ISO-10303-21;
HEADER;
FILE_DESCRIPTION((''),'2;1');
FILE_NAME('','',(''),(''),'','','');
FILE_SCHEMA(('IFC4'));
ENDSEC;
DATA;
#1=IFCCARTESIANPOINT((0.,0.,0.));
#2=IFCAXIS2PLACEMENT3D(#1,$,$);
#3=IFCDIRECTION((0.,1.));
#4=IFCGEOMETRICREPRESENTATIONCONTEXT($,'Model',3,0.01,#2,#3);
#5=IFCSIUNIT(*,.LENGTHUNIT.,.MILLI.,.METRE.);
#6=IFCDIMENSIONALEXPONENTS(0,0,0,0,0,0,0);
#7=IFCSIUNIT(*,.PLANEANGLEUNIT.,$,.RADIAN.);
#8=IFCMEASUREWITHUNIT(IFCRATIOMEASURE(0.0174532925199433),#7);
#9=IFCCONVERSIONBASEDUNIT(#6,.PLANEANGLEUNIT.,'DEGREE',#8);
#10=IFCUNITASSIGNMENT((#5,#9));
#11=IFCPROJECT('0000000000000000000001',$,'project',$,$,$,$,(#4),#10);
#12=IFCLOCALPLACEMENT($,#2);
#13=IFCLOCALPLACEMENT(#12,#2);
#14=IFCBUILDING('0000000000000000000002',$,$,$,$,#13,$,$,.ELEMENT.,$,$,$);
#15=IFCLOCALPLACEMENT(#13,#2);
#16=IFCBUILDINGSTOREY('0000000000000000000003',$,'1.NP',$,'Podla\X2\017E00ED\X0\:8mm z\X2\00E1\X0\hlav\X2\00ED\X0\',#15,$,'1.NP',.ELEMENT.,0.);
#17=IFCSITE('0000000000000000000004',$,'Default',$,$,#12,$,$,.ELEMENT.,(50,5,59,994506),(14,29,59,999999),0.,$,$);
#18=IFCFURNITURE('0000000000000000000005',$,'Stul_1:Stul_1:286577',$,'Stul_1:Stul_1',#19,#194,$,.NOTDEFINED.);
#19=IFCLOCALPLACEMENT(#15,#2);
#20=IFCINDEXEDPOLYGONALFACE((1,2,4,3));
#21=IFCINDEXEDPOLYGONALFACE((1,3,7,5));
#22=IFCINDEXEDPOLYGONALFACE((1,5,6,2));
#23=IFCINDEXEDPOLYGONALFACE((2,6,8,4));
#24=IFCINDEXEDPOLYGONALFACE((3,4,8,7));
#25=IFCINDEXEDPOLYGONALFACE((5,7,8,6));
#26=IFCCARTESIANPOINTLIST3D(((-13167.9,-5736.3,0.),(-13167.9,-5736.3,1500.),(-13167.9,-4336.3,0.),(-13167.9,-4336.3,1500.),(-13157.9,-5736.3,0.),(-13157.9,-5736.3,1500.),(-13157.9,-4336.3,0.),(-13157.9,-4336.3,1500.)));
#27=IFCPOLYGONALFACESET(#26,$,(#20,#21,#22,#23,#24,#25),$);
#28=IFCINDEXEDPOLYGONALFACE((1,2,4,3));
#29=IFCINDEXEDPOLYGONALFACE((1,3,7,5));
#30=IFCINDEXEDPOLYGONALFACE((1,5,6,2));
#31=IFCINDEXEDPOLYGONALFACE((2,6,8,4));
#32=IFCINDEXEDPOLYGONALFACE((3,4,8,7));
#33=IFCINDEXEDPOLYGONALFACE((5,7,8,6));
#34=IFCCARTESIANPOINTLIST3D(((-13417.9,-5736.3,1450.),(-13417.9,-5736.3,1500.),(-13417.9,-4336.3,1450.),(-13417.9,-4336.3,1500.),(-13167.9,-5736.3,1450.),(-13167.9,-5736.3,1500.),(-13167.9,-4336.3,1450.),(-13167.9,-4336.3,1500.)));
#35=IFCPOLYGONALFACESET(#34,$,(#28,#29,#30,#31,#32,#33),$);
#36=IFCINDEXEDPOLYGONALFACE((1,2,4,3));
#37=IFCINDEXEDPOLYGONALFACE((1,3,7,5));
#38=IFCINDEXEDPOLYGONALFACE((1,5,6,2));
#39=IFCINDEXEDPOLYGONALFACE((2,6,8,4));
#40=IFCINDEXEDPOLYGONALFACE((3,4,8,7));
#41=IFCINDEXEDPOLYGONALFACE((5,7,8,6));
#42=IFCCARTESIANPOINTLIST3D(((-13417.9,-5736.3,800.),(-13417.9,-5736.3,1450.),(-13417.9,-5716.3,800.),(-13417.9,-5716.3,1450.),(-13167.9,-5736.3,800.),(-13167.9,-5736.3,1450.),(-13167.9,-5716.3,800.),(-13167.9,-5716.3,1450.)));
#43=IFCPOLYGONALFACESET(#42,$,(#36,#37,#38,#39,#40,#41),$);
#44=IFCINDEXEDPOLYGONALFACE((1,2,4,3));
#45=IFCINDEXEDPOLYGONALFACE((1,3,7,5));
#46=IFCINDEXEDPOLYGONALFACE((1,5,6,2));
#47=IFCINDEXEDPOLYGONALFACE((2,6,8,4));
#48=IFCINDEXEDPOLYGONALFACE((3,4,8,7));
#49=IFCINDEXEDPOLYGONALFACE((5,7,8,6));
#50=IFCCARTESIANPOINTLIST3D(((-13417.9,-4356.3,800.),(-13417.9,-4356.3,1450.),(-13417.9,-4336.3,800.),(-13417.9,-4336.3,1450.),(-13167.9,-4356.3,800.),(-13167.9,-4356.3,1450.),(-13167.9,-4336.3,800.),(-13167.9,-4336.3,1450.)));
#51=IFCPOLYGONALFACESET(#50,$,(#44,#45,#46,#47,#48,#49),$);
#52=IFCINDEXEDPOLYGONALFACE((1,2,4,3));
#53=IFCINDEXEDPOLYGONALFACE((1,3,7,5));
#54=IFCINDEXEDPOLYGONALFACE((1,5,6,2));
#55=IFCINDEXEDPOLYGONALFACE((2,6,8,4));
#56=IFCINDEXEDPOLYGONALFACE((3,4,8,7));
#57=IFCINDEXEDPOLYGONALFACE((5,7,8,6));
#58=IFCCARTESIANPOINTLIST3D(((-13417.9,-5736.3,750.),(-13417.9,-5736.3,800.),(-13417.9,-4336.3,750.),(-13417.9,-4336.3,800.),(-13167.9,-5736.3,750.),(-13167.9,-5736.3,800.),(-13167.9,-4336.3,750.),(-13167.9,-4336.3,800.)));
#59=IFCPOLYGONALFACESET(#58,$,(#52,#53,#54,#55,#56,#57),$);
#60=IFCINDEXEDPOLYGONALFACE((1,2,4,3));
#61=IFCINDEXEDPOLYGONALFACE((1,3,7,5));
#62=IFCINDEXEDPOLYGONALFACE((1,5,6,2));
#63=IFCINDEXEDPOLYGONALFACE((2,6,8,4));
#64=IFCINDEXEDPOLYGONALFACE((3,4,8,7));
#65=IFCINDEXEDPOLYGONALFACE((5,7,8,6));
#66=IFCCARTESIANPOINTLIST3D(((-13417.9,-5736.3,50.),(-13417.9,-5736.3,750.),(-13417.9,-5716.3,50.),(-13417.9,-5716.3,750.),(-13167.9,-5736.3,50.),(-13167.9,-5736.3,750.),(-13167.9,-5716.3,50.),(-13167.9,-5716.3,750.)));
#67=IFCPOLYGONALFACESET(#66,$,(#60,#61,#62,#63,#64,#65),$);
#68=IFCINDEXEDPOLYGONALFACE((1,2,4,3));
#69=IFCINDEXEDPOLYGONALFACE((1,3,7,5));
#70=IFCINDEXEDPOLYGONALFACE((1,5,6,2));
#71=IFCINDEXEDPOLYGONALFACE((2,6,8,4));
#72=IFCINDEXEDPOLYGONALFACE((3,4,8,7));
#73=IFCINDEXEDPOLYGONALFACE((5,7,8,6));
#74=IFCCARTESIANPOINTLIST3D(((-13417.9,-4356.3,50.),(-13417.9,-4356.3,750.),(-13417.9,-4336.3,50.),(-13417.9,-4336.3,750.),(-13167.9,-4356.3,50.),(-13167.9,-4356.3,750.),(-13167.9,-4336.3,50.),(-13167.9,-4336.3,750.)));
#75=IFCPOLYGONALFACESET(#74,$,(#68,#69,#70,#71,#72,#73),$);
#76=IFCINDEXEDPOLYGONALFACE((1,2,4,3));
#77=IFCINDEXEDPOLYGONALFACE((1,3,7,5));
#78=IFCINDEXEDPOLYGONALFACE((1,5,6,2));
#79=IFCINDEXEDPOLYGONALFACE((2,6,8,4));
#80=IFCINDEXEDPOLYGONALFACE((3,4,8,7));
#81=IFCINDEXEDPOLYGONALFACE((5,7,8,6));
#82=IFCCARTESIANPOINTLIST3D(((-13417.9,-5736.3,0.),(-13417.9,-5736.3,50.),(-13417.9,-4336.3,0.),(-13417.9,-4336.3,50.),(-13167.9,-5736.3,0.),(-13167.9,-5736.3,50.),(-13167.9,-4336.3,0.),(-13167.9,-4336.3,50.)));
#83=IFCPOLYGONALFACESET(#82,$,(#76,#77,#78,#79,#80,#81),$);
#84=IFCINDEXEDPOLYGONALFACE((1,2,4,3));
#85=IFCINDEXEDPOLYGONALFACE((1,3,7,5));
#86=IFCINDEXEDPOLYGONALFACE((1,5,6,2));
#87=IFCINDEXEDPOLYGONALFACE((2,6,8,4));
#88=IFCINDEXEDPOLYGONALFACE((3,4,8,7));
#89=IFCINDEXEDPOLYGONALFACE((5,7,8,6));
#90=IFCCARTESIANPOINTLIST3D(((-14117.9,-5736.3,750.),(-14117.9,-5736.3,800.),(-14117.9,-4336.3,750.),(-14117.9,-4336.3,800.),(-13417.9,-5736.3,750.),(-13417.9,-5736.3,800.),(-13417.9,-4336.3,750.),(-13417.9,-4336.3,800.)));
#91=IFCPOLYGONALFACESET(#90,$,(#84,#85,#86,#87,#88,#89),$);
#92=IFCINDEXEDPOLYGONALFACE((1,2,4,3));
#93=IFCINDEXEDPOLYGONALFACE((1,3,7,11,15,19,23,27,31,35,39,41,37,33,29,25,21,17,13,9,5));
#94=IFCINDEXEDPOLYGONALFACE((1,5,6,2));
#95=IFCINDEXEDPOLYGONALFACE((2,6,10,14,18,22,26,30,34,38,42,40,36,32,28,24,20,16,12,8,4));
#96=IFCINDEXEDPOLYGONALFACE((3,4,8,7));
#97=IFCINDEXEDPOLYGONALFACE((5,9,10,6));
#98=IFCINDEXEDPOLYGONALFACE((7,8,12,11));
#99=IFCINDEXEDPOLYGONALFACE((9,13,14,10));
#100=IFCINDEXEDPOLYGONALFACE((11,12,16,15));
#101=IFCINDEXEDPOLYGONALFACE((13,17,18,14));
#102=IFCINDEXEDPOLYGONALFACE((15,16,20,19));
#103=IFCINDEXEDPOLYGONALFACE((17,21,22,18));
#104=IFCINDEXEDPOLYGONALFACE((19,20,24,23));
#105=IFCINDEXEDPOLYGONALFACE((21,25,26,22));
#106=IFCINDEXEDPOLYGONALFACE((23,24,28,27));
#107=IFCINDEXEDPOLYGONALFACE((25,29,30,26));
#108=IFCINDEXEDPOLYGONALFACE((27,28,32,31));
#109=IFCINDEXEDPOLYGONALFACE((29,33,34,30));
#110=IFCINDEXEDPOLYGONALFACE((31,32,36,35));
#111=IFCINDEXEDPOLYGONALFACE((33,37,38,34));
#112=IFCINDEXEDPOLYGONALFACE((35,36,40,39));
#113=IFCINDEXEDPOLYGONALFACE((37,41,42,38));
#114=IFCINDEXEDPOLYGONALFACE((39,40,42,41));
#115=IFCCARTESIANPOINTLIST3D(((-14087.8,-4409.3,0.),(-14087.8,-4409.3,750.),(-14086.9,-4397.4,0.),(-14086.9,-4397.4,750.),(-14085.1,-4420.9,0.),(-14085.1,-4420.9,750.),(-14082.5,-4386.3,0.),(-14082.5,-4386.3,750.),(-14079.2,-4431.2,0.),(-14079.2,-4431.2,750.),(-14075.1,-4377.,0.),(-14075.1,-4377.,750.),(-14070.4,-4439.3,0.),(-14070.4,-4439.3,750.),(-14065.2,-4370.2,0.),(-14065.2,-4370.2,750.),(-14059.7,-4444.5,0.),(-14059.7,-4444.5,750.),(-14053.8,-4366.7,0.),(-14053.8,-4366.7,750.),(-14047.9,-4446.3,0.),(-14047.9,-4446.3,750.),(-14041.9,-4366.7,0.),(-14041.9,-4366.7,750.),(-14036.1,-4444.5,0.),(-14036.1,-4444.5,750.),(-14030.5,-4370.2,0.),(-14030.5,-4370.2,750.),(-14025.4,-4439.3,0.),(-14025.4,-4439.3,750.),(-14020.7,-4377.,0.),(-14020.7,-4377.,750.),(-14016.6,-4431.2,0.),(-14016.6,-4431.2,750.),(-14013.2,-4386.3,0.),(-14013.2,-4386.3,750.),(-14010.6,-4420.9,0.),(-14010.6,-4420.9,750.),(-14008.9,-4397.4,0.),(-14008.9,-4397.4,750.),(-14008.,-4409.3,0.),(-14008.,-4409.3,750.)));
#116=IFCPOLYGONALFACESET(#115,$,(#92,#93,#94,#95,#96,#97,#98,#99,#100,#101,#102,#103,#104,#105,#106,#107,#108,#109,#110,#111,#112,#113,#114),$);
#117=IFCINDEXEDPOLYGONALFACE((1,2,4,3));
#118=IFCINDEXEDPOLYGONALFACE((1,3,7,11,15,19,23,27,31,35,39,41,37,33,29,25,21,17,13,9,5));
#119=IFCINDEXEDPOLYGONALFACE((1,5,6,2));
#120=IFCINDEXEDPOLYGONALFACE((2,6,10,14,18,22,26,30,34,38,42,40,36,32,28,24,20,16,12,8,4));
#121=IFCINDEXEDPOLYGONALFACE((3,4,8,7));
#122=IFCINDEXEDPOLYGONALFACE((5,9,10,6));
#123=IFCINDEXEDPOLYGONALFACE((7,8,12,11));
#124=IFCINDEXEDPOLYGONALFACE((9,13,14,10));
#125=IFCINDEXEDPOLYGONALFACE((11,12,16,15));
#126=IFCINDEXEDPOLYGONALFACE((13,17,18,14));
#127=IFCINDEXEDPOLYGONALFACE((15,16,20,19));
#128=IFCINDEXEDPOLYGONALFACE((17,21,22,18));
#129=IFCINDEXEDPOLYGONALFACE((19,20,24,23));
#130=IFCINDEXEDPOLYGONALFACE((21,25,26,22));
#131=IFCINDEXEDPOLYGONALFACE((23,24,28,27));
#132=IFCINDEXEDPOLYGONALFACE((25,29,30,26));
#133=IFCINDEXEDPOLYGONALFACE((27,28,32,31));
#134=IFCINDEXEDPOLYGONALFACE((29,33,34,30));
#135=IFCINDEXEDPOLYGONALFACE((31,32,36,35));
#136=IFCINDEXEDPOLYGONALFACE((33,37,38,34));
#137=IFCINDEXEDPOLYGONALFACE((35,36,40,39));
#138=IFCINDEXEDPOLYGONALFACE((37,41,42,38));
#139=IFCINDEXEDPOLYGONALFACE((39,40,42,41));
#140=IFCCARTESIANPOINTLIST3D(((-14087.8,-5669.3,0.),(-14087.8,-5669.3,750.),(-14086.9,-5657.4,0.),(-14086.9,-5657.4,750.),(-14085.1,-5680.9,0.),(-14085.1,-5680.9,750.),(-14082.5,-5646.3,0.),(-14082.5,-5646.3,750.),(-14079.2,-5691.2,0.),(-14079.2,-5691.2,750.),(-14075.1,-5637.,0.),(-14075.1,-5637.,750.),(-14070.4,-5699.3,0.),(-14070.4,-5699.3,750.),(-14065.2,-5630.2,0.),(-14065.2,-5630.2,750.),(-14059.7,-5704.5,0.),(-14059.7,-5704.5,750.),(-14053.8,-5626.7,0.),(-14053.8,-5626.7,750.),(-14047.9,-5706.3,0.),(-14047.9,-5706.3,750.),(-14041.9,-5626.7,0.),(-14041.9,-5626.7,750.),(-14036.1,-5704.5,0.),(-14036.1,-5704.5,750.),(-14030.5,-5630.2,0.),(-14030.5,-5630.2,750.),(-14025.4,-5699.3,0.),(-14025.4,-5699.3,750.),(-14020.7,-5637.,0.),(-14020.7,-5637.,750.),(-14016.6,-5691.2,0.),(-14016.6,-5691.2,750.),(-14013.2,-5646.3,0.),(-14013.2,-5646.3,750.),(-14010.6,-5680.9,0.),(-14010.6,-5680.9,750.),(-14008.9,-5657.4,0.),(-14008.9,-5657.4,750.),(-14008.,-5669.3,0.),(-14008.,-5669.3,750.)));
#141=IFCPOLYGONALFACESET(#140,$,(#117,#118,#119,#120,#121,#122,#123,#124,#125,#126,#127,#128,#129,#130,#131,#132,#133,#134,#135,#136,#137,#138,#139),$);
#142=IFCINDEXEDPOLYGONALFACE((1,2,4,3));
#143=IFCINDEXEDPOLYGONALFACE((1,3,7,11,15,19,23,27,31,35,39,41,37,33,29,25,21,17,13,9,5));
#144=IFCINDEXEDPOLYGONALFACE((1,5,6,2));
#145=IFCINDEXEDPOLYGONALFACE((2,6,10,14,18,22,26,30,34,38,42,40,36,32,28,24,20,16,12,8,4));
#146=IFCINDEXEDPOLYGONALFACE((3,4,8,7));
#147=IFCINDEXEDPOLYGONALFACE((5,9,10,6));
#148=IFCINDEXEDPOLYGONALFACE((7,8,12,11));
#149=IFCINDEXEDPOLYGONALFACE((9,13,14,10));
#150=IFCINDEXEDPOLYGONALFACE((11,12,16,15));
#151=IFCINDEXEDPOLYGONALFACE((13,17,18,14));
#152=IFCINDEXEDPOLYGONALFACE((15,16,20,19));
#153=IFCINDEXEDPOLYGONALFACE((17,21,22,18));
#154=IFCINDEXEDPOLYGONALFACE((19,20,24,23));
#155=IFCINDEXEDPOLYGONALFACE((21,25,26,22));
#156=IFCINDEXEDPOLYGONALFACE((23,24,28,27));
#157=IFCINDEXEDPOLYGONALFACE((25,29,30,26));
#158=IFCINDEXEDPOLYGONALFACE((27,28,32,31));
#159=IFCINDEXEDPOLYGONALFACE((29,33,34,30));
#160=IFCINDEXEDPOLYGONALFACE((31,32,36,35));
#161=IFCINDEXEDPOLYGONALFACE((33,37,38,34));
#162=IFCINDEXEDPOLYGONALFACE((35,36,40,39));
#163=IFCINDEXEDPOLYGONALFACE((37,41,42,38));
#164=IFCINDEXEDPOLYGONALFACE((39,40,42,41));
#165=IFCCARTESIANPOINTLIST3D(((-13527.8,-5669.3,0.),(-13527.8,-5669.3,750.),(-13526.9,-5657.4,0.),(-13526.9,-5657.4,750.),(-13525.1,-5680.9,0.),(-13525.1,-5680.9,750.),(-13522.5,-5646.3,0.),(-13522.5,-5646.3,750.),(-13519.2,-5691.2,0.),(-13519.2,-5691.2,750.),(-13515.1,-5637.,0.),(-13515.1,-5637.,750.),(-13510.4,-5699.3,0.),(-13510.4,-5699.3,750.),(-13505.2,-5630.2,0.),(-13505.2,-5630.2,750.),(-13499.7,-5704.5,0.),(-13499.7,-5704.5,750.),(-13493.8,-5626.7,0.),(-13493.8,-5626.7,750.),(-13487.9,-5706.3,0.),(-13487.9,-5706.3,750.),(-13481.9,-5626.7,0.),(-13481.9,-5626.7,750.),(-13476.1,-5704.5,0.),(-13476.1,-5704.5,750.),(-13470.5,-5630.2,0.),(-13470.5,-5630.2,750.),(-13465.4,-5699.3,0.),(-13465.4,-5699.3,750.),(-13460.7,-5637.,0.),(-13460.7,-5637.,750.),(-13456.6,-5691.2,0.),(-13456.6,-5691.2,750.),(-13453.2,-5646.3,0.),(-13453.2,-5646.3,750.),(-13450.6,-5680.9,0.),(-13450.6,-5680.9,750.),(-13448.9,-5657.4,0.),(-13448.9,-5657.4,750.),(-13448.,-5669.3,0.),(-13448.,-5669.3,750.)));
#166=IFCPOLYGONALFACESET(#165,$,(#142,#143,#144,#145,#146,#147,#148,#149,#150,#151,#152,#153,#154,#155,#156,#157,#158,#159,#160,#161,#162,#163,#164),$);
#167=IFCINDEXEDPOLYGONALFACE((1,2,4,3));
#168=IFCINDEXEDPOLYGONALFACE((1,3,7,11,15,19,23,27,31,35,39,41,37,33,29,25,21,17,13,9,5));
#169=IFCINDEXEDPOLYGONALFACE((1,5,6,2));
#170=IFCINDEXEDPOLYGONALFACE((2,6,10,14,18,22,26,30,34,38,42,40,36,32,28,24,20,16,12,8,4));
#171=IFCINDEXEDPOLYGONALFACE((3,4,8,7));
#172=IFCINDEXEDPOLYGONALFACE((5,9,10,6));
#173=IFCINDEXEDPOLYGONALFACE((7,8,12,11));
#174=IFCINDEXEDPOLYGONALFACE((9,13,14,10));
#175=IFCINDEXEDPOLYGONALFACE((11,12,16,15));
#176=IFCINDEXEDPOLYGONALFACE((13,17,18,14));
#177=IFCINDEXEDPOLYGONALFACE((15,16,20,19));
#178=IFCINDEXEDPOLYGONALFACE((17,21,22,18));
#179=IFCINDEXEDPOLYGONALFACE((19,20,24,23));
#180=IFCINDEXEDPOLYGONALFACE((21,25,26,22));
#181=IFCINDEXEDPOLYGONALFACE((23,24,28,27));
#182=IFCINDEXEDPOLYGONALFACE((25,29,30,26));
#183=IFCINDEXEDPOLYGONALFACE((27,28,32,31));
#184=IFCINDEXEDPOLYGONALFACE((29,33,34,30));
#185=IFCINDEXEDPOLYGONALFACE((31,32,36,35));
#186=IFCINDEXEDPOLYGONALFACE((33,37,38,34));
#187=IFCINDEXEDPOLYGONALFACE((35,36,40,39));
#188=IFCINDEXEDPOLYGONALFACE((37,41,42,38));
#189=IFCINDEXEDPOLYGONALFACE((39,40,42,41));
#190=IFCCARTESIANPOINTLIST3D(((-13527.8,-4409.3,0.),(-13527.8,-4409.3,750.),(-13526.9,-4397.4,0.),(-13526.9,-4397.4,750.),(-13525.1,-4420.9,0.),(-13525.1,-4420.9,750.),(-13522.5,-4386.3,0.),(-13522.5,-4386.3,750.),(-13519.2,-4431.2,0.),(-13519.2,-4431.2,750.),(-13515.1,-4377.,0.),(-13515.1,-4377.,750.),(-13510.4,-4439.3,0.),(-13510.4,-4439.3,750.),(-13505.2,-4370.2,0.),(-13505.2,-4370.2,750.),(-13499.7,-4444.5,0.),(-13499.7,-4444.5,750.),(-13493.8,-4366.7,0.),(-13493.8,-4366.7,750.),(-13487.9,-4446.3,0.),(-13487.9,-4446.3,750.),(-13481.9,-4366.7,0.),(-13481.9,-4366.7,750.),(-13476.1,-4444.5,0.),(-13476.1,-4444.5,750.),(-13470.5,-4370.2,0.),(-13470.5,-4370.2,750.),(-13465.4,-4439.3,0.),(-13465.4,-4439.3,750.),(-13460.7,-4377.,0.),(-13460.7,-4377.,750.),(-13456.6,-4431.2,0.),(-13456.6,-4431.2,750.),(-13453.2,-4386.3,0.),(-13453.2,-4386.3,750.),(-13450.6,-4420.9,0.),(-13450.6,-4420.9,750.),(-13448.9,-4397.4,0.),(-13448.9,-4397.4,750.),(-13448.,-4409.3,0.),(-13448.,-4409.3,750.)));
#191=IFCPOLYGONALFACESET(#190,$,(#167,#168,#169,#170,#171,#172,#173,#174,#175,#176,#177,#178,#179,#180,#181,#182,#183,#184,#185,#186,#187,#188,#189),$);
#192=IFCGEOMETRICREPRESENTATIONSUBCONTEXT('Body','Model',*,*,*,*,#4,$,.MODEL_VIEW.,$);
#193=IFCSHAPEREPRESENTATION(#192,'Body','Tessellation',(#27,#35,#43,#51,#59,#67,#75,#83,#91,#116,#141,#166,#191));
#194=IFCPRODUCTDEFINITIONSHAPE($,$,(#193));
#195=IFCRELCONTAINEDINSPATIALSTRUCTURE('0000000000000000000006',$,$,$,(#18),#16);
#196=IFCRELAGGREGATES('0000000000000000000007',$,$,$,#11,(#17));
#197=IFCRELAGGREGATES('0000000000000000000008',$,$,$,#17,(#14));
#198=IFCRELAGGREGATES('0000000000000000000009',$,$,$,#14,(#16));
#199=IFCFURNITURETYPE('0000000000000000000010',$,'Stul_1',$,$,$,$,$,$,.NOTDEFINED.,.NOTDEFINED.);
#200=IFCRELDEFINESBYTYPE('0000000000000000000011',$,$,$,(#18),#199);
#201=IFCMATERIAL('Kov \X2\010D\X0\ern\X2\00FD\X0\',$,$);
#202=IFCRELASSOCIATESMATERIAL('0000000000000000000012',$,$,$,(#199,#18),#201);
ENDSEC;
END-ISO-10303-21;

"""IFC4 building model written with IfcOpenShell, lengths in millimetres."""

from ifc_helpers import new_model, entity, si_unit, converted_unit, direction, frame, frame_2d, origin, origin_2d_with_axis, place, context, subcontext, project, spatial, rectangle, circle, extrude, source, transform, mapped, material, type_object, type_shapes, element, save


model = new_model("IFC4")

# Units and contexts
model_context = context("Model", 3, precision=0.01, world=origin(), true_north=direction((0.0, 1.0)))
body_context = subcontext(model_context, "Body", "Model", "MODEL_VIEW")
ifc_project = project(units=[si_unit("LENGTHUNIT", "METRE", prefix="MILLI"), converted_unit("PLANEANGLEUNIT", "DEGREE", entity("IfcRatioMeasure", 0.0174532925199433), si_unit("PLANEANGLEUNIT", "RADIAN"), dimensions=[0, 0, 0, 0, 0, 0, 0])], contexts=[model_context])

# Site, building, storey
site_placement = place(None, origin())
site = spatial("IfcSite", under=ifc_project, at=site_placement, Name="Default", CompositionType="ELEMENT", RefLatitude=(50, 5, 59, 994506), RefLongitude=(14, 29, 59, 999999), RefElevation=0.0)
building_placement = place(site_placement, origin())
building = spatial("IfcBuilding", under=site, at=building_placement, CompositionType="ELEMENT")
storey_placement = place(building_placement, origin())
storey = spatial("IfcBuildingStorey", under=building, at=storey_placement, Name="1.NP", ObjectType="Podlaží:8mm záhlaví", LongName="1.NP", CompositionType="ELEMENT", Elevation=0.0)

# Furniture
ifc_material_1 = material(Name="Kov černý")
furniture_type = type_object("IfcFurnitureType", Name="Stul_1", AssemblyPlace="NOTDEFINED", PredefinedType="NOTDEFINED", material=ifc_material_1)
shared_shape_1 = source(origin(), body_context, "Body", "SweptSolid", [
    extrude(rectangle(XDim=1400.0, YDim=10.0, at=origin_2d_with_axis()), frame((0.0, 605.0, 0.0), z_axis=(0.0, 0.0, 1.0), x_axis=(-1.0, 0.0, 0.0)), (0.0, 0.0, 1.0), 1500.0),
    extrude(rectangle(XDim=1400.0, YDim=250.0, at=frame_2d((0.0, 0.0), x_axis=(1.0, 0.0))), frame((0.0, 475.0, 1450.0), z_axis=(0.0, 0.0, 1.0), x_axis=(-1.0, 0.0, 0.0)), (0.0, 0.0, 1.0), 50.0),
    extrude(rectangle(XDim=20.0, YDim=250.0, at=origin_2d_with_axis()), frame((690.0, 475.0, 800.0), z_axis=(0.0, 0.0, 1.0), x_axis=(-1.0, 0.0, 0.0)), (0.0, 0.0, 1.0), 650.0),
    extrude(rectangle(XDim=20.0, YDim=250.0, at=frame_2d((0.0, 0.0), x_axis=(1.0, 0.0))), frame((-690.0, 475.0, 800.0), z_axis=(0.0, 0.0, 1.0), x_axis=(-1.0, 0.0, 0.0)), (0.0, 0.0, 1.0), 650.0),
    extrude(rectangle(XDim=1400.0, YDim=250.0, at=origin_2d_with_axis()), frame((0.0, 475.0, 750.0), z_axis=(0.0, 0.0, 1.0), x_axis=(-1.0, 0.0, 0.0)), (0.0, 0.0, 1.0), 50.0),
    extrude(rectangle(XDim=20.0, YDim=250.0, at=origin_2d_with_axis()), frame((690.0, 475.0, 50.0), z_axis=(0.0, 0.0, 1.0), x_axis=(-1.0, 0.0, 0.0)), (0.0, 0.0, 1.0), 700.0),
    extrude(rectangle(XDim=20.0, YDim=250.0, at=frame_2d((0.0, 0.0), x_axis=(1.0, 0.0))), frame((-690.0, 475.0, 50.0), z_axis=(0.0, 0.0, 1.0), x_axis=(-1.0, 0.0, 0.0)), (0.0, 0.0, 1.0), 700.0),
    extrude(rectangle(XDim=1400.0, YDim=250.0, at=origin_2d_with_axis()), frame((0.0, 475.0, 0.0), z_axis=(0.0, 0.0, 1.0), x_axis=(-1.0, 0.0, 0.0)), (0.0, 0.0, 1.0), 50.0),
    extrude(rectangle(XDim=1400.0, YDim=700.0, at=origin_2d_with_axis()), frame((0.0, 0.0, 750.0), z_axis=(0.0, 0.0, 1.0), x_axis=(-1.0, 0.0, 0.0)), (0.0, 0.0, 1.0), 50.0),
    extrude(circle(Radius=40.0, at=frame_2d((0.0, 0.0), x_axis=(1.0, 0.0))), frame((-630.0, -280.0, 0.0)), (0.0, 0.0, 1.0), 750.0),
    extrude(circle(Radius=40.0, at=frame_2d((0.0, 0.0), x_axis=(1.0, 0.0))), frame((630.0, -280.0, 0.0)), (0.0, 0.0, 1.0), 750.0),
    extrude(circle(Radius=40.0, at=frame_2d((0.0, 0.0), x_axis=(1.0, 0.0))), frame((630.0, 280.0, 0.0)), (0.0, 0.0, 1.0), 750.0),
    extrude(circle(Radius=40.0, at=frame_2d((0.0, 0.0), x_axis=(1.0, 0.0))), frame((-630.0, 280.0, 0.0)), (0.0, 0.0, 1.0), 750.0),
])
type_shapes(furniture_type, [shared_shape_1])
for number, where, z_axis, x_axis, name in (
    (1, (-13767.9, -5036.3, 0.0), (0.0, 0.0, 1.0), (0.0, -1.0, 0.0), "Stul_1:Stul_1:286577"),
):
    element("IfcFurniture", number, at=place(storey_placement, frame(where, z_axis=z_axis, x_axis=x_axis)), inside=storey, type_object=furniture_type, material=ifc_material_1, Name=name, ObjectType="Stul_1:Stul_1", PredefinedType="NOTDEFINED", context=body_context, shape_type="MappedRepresentation", body=[
        mapped(shared_shape_1, transform((0.0, 0.0, 0.0), scale=1.0)),
    ])

save(model, "model.ifc")
